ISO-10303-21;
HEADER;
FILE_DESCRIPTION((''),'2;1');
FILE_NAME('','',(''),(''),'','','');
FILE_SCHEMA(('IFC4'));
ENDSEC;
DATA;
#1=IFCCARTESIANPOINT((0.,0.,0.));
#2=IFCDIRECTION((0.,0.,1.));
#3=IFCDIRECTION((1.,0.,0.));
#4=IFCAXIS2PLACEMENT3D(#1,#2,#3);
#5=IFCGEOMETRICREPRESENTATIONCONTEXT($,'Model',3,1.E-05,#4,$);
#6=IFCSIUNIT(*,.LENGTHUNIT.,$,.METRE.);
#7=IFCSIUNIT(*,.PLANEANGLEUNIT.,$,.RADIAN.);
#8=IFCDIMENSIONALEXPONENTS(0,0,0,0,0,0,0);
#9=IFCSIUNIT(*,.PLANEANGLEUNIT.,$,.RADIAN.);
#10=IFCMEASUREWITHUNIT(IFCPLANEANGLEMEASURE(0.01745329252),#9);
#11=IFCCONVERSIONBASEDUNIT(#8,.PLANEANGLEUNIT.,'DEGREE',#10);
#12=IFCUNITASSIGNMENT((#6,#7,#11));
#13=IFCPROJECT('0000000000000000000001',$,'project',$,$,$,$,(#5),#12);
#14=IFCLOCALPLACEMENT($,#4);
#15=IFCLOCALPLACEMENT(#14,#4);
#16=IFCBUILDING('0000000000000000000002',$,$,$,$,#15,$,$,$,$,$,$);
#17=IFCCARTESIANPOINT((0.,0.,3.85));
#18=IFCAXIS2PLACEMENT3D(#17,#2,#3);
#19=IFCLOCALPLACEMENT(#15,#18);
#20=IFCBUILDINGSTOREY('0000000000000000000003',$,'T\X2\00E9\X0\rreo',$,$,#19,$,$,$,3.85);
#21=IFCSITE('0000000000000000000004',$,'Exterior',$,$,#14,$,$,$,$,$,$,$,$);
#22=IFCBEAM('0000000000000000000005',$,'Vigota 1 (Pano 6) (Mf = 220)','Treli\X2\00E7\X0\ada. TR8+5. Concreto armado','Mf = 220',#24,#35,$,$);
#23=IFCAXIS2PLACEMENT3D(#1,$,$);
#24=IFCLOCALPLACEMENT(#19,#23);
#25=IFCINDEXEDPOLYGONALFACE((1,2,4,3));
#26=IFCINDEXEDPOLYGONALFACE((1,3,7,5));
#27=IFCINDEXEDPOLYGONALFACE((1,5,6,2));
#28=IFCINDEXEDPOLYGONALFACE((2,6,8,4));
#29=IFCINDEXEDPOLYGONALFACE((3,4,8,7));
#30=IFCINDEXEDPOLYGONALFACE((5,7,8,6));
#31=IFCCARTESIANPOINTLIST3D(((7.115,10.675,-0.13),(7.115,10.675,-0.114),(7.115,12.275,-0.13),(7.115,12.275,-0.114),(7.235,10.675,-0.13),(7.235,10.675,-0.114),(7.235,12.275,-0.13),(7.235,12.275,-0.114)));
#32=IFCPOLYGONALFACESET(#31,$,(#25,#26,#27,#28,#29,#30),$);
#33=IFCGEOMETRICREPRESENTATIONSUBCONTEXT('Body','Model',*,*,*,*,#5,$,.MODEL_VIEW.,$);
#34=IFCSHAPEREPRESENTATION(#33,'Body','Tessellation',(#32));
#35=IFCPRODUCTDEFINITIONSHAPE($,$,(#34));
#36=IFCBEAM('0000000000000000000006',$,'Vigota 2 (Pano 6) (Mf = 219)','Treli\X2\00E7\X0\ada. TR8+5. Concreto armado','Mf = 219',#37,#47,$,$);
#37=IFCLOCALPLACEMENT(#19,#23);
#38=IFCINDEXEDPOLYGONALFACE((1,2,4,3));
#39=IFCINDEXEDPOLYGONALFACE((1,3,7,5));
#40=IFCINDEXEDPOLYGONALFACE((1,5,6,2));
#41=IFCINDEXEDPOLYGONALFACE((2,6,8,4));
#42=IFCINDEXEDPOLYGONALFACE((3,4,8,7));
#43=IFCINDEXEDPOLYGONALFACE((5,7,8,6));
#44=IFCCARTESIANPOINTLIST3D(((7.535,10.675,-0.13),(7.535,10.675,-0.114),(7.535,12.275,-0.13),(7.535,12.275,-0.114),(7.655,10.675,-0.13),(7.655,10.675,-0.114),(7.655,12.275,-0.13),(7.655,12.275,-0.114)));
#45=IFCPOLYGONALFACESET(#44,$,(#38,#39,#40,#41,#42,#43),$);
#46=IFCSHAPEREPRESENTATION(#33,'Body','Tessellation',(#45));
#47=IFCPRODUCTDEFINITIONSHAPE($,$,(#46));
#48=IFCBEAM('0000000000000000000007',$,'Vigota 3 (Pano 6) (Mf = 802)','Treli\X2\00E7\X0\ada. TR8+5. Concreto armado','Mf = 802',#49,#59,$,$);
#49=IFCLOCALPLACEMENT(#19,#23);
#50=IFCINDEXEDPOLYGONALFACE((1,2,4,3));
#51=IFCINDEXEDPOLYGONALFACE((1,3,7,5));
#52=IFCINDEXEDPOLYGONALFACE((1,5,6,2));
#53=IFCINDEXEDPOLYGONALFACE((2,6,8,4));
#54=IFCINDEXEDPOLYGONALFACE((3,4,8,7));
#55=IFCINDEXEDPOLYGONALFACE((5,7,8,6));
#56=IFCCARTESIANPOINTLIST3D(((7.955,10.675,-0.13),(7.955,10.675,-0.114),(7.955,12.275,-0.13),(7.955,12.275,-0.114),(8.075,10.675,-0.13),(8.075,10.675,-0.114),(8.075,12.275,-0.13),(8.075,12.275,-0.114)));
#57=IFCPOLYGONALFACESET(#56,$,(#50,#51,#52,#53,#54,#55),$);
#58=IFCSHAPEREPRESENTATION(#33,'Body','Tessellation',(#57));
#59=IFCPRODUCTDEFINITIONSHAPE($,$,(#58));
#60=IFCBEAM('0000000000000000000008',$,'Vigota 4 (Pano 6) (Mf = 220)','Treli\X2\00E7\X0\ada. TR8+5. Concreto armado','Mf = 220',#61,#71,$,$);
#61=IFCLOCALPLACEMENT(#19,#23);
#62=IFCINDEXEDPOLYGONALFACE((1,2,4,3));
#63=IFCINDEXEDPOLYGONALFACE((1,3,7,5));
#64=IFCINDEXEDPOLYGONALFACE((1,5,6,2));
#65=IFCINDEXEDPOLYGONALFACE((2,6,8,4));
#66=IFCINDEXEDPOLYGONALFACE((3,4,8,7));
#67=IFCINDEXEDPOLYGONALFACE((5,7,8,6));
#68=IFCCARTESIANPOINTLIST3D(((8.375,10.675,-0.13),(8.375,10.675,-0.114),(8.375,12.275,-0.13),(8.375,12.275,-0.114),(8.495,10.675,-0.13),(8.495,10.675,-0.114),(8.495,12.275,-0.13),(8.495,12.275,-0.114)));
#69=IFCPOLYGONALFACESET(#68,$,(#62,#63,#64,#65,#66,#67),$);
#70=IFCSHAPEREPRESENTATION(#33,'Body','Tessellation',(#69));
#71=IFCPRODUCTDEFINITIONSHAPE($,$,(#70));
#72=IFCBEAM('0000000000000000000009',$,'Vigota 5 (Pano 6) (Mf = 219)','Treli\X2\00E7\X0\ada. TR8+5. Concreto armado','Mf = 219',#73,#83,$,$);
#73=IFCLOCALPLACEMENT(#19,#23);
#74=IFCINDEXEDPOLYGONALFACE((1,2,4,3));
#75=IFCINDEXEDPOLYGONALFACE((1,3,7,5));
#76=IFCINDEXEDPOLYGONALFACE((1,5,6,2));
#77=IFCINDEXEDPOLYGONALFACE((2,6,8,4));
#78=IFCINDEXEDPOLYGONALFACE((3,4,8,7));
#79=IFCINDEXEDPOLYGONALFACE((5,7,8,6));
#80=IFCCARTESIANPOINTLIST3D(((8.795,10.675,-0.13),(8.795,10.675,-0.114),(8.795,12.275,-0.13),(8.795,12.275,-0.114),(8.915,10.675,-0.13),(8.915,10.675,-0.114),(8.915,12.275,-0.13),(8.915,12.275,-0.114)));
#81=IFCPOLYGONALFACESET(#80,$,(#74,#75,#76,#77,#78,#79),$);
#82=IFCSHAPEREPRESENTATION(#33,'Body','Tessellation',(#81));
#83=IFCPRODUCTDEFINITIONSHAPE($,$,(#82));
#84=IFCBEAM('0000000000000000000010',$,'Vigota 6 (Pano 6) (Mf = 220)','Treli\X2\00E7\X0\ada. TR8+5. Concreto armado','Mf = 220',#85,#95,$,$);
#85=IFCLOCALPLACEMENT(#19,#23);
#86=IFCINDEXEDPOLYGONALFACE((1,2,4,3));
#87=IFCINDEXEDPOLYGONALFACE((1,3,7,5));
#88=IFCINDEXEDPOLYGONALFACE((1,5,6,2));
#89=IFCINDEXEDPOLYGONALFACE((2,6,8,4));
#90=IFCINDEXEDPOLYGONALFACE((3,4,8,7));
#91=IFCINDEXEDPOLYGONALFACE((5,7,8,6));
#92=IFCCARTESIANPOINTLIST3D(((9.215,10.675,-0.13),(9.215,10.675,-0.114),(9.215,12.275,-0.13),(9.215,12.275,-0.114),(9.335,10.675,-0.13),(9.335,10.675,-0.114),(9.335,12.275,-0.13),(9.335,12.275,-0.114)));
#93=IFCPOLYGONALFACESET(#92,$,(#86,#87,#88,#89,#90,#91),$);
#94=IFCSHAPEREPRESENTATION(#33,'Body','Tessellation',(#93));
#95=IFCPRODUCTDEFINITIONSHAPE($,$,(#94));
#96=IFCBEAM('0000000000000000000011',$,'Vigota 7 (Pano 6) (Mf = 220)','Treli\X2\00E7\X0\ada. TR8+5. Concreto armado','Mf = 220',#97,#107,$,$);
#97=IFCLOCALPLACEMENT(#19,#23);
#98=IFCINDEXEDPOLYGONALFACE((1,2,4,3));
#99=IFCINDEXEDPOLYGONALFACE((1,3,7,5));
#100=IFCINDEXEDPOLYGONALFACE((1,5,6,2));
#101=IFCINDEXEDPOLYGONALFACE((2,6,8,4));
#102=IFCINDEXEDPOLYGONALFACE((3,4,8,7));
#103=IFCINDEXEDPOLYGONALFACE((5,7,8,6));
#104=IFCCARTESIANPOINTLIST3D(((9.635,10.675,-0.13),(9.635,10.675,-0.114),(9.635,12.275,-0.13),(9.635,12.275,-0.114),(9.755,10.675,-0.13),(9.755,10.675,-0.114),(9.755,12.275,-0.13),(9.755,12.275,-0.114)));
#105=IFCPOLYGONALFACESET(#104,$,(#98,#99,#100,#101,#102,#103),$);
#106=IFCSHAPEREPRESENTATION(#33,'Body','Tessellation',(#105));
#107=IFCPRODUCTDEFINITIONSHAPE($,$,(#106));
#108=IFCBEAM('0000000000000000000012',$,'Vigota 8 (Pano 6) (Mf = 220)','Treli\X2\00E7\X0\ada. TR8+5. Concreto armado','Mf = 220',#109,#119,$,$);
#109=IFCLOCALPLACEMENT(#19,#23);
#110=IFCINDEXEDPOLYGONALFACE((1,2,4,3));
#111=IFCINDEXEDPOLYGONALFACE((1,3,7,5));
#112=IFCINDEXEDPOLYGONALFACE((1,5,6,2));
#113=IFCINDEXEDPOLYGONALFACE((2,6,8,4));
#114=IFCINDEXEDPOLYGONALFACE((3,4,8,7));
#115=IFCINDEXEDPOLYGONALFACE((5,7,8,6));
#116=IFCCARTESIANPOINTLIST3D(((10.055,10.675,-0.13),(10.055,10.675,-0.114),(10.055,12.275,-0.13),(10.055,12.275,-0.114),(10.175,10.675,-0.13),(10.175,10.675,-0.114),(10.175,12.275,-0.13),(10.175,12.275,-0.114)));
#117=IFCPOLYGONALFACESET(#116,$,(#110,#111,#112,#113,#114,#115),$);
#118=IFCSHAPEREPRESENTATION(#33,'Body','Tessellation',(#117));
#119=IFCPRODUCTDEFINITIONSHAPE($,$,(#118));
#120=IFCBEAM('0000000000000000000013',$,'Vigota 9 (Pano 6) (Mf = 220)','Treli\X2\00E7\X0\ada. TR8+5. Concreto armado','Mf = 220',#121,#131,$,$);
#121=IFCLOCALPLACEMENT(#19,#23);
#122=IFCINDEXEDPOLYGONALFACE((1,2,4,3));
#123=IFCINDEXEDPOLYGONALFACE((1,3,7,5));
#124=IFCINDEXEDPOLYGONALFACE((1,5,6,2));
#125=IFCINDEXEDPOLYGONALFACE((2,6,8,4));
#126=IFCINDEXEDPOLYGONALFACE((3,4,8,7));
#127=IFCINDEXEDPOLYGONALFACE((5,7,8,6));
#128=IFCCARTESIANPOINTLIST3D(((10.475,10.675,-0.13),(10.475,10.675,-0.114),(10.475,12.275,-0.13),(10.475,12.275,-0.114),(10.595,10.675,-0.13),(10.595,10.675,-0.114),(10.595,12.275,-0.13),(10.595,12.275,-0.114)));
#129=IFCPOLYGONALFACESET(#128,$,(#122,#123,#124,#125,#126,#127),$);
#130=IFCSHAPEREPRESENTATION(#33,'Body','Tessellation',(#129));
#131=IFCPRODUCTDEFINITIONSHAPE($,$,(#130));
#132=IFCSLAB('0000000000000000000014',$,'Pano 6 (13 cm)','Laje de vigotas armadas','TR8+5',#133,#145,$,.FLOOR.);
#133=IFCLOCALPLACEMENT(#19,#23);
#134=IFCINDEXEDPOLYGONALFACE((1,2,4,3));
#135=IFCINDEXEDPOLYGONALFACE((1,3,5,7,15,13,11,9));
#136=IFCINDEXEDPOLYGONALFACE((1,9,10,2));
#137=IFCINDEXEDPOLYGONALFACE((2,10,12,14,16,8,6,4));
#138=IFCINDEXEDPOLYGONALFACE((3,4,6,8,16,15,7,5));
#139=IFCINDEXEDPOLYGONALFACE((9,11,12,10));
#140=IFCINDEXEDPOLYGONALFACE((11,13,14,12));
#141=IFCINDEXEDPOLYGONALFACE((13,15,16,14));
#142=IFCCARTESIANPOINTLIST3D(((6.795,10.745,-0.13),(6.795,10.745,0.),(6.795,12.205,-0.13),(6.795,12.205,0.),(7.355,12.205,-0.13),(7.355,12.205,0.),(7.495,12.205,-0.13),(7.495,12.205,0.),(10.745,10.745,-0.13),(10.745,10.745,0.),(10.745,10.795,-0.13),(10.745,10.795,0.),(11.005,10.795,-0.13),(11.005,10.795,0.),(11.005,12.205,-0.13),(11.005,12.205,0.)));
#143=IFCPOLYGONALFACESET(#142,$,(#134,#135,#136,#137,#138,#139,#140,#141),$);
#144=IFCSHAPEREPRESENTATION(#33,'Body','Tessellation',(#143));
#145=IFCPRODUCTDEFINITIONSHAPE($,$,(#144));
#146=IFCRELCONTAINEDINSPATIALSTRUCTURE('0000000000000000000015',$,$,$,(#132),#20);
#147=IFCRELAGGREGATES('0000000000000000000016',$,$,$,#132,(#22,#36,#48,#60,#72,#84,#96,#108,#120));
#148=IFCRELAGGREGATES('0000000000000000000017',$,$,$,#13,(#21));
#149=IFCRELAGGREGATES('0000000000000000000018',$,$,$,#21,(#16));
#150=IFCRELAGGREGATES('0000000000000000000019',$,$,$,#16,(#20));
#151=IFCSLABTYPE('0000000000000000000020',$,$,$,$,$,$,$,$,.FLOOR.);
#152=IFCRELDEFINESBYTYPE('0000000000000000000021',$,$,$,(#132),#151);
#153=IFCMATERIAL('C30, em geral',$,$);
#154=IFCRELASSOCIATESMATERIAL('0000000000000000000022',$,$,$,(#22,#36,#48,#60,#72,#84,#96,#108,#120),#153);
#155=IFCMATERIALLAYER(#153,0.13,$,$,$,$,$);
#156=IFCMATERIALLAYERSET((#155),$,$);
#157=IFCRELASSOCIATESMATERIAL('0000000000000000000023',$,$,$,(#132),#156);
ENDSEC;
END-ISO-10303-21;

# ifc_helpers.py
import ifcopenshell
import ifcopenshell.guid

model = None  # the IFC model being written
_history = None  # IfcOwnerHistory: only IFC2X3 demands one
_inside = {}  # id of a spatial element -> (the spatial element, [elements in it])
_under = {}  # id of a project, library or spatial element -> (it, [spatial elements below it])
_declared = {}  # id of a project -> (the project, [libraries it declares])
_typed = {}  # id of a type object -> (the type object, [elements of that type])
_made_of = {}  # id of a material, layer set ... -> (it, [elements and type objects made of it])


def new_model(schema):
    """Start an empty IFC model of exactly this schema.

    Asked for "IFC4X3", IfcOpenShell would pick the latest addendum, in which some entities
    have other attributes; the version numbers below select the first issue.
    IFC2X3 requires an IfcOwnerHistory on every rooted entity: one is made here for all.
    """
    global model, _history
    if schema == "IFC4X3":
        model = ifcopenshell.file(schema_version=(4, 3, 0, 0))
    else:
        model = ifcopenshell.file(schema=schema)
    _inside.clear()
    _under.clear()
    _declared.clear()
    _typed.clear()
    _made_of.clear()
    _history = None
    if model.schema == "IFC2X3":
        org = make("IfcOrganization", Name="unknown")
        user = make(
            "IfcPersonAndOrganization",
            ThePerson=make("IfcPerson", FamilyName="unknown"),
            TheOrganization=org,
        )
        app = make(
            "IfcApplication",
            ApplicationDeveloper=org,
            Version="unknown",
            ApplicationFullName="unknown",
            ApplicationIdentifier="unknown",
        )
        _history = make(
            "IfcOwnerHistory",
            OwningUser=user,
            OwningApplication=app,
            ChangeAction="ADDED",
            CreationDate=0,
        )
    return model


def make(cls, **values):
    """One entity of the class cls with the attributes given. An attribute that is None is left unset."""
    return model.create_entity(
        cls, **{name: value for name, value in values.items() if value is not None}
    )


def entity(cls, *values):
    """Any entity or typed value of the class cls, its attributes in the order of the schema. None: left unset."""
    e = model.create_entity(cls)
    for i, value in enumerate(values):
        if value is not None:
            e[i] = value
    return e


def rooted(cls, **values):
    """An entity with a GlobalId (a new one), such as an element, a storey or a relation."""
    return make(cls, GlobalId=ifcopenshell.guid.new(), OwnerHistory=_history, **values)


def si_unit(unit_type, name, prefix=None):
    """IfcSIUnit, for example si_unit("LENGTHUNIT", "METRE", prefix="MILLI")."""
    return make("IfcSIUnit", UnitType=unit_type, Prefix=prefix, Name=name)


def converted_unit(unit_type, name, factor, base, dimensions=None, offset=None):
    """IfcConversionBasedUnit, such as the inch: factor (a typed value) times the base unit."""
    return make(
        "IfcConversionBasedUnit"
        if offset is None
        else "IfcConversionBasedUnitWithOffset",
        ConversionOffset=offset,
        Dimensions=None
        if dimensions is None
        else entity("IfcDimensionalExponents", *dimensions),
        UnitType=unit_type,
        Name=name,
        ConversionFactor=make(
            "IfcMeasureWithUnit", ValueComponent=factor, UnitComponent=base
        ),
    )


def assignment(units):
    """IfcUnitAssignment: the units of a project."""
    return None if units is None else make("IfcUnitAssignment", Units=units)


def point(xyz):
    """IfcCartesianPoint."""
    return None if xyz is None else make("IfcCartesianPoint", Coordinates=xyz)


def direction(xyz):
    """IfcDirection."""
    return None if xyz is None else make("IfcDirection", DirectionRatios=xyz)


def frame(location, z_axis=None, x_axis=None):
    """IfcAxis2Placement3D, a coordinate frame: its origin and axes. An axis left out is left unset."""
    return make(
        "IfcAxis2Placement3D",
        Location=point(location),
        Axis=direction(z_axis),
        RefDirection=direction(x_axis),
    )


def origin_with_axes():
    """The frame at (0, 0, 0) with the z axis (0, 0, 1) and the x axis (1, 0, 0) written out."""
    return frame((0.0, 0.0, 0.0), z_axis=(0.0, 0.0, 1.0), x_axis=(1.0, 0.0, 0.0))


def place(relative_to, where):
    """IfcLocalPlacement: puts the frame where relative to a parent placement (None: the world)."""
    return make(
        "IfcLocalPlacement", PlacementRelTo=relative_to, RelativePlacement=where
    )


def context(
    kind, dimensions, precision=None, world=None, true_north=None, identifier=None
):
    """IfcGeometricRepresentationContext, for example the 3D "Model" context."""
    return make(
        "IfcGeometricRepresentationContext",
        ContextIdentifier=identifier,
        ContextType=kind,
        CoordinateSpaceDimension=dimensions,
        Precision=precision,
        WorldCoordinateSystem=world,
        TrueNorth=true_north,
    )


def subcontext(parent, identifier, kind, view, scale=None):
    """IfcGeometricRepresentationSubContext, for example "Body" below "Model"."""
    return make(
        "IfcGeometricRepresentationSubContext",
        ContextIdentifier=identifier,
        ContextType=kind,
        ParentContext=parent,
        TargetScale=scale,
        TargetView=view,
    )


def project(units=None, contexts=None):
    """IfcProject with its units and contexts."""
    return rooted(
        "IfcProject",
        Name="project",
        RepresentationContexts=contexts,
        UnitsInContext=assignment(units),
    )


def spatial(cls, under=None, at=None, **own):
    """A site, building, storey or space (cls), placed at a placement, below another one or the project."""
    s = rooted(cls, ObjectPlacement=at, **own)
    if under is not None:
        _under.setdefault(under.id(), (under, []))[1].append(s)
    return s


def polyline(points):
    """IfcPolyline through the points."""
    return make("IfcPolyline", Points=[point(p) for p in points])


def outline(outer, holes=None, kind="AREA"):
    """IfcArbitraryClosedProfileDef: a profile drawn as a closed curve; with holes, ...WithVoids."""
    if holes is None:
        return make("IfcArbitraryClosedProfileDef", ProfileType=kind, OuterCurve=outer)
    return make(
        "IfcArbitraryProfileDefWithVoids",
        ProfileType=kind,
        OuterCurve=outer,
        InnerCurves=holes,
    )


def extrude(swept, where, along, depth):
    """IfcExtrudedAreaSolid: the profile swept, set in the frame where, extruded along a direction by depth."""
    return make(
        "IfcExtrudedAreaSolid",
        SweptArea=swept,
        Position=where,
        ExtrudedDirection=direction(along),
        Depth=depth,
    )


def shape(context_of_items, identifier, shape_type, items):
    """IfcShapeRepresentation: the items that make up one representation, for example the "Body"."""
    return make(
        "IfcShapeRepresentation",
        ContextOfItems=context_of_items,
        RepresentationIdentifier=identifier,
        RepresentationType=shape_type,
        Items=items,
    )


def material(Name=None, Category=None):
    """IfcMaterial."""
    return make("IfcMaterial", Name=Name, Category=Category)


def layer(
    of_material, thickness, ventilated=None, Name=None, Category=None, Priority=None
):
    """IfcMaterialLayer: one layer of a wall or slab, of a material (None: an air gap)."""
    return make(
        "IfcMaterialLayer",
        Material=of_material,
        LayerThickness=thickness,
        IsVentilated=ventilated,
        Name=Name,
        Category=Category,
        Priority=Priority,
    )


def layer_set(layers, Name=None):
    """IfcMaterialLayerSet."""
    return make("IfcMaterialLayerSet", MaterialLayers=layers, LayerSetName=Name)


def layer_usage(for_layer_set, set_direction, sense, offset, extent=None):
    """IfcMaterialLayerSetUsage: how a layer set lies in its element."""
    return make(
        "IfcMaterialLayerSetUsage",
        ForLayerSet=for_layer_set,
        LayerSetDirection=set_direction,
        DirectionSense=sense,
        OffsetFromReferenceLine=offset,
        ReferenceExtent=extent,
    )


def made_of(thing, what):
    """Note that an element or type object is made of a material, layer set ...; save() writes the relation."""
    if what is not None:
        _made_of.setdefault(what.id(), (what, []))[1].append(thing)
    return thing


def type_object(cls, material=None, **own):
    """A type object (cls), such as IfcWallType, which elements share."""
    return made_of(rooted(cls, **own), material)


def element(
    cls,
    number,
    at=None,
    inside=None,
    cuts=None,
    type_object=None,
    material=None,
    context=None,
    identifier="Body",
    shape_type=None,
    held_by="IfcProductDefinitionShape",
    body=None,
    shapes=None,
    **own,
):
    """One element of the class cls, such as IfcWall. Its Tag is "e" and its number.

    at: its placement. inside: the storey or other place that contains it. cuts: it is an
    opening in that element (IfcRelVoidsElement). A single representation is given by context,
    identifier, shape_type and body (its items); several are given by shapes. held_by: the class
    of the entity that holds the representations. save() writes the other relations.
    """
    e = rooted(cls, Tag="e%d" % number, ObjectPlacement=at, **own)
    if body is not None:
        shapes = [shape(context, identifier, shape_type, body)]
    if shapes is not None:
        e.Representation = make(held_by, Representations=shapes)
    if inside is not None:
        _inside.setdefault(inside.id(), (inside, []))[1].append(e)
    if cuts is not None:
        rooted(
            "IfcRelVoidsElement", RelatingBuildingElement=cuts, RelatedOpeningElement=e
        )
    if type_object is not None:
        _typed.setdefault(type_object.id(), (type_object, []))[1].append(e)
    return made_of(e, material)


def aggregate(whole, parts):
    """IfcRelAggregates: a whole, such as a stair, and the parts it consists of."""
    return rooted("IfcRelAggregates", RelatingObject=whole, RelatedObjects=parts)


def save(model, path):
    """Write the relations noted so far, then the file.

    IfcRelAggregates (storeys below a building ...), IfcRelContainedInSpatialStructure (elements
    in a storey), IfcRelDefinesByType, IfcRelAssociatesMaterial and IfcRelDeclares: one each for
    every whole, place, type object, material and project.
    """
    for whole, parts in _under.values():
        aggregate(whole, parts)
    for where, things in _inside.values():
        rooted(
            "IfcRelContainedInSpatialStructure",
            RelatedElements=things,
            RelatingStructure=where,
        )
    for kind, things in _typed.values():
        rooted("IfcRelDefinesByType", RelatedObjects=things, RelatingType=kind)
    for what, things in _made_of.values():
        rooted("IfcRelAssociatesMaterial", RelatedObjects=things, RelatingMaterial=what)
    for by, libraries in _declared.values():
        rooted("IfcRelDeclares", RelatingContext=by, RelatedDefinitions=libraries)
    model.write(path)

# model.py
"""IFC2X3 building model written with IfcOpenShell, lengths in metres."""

from ifc_helpers import new_model, entity, si_unit, converted_unit, frame, origin_with_axes, place, context, subcontext, project, spatial, polyline, outline, extrude, material, layer, layer_set, layer_usage, type_object, element, aggregate, save


model = new_model("IFC2X3")

# Units and contexts
model_context = context("Model", 3, precision=1e-05, world=origin_with_axes())
body_context = subcontext(model_context, "Body", "Model", "MODEL_VIEW")
ifc_project = project(units=[si_unit("LENGTHUNIT", "METRE"), si_unit("PLANEANGLEUNIT", "RADIAN"), converted_unit("PLANEANGLEUNIT", "DEGREE", entity("IfcPlaneAngleMeasure", 0.01745329252), si_unit("PLANEANGLEUNIT", "RADIAN"), dimensions=[0, 0, 0, 0, 0, 0, 0])], contexts=[model_context])

# Beams
ifc_material = material(Name="C30, em geral")
site_placement = place(None, origin_with_axes())
building_placement = place(site_placement, origin_with_axes())
storey_placement = place(building_placement, frame((0.0, 0.0, 3.85), z_axis=(0.0, 0.0, 1.0), x_axis=(1.0, 0.0, 0.0)))
beam_1_placement = place(storey_placement, frame((7.175, 10.675, -0.122), z_axis=(0.0, 1.0, 0.0), x_axis=(-1.0, 0.0, 0.0)))
beam_1 = element("IfcBeam", 1, at=beam_1_placement, material=ifc_material, Name="Vigota 1 (Pano 6) (Mf = 220)", Description="Treliçada. TR8+5. Concreto armado", ObjectType="Mf = 220", context=body_context, shape_type="SweptSolid", body=[
    extrude(outline(polyline([(0.06, 0.008), (-0.06, 0.008), (-0.06, -0.008), (0.06, -0.008), (0.06, 0.008)])), origin_with_axes(), (0.0, 0.0, 1.0), 1.6),
])
beam_2_placement = place(storey_placement, frame((7.595, 10.675, -0.122), z_axis=(0.0, 1.0, 0.0), x_axis=(-1.0, 0.0, 0.0)))
beam_2 = element("IfcBeam", 2, at=beam_2_placement, material=ifc_material, Name="Vigota 2 (Pano 6) (Mf = 219)", Description="Treliçada. TR8+5. Concreto armado", ObjectType="Mf = 219", context=body_context, shape_type="SweptSolid", body=[
    extrude(outline(polyline([(0.06, 0.008), (-0.06, 0.008), (-0.06, -0.008), (0.06, -0.008), (0.06, 0.008)])), origin_with_axes(), (0.0, 0.0, 1.0), 1.6),
])
beam_3_placement = place(storey_placement, frame((8.015, 10.675, -0.122), z_axis=(0.0, 1.0, 0.0), x_axis=(-1.0, 0.0, 0.0)))
beam_3 = element("IfcBeam", 3, at=beam_3_placement, material=ifc_material, Name="Vigota 3 (Pano 6) (Mf = 802)", Description="Treliçada. TR8+5. Concreto armado", ObjectType="Mf = 802", context=body_context, shape_type="SweptSolid", body=[
    extrude(outline(polyline([(0.06, 0.008), (-0.06, 0.008), (-0.06, -0.008), (0.06, -0.008), (0.06, 0.008)])), origin_with_axes(), (0.0, 0.0, 1.0), 1.6),
])
beam_4_placement = place(storey_placement, frame((8.435, 10.675, -0.122), z_axis=(0.0, 1.0, 0.0), x_axis=(-1.0, 0.0, 0.0)))
beam_4 = element("IfcBeam", 4, at=beam_4_placement, material=ifc_material, Name="Vigota 4 (Pano 6) (Mf = 220)", Description="Treliçada. TR8+5. Concreto armado", ObjectType="Mf = 220", context=body_context, shape_type="SweptSolid", body=[
    extrude(outline(polyline([(0.06, 0.008), (-0.06, 0.008), (-0.06, -0.008), (0.06, -0.008), (0.06, 0.008)])), origin_with_axes(), (0.0, 0.0, 1.0), 1.6),
])
beam_5_placement = place(storey_placement, frame((8.855, 10.675, -0.122), z_axis=(0.0, 1.0, 0.0), x_axis=(-1.0, 0.0, 0.0)))
beam_5 = element("IfcBeam", 5, at=beam_5_placement, material=ifc_material, Name="Vigota 5 (Pano 6) (Mf = 219)", Description="Treliçada. TR8+5. Concreto armado", ObjectType="Mf = 219", context=body_context, shape_type="SweptSolid", body=[
    extrude(outline(polyline([(0.06, 0.008), (-0.06, 0.008), (-0.06, -0.008), (0.06, -0.008), (0.06, 0.008)])), origin_with_axes(), (0.0, 0.0, 1.0), 1.6),
])
beam_6_placement = place(storey_placement, frame((9.275, 10.675, -0.122), z_axis=(0.0, 1.0, 0.0), x_axis=(-1.0, 0.0, 0.0)))
beam_6 = element("IfcBeam", 6, at=beam_6_placement, material=ifc_material, Name="Vigota 6 (Pano 6) (Mf = 220)", Description="Treliçada. TR8+5. Concreto armado", ObjectType="Mf = 220", context=body_context, shape_type="SweptSolid", body=[
    extrude(outline(polyline([(0.06, 0.008), (-0.06, 0.008), (-0.06, -0.008), (0.06, -0.008), (0.06, 0.008)])), origin_with_axes(), (0.0, 0.0, 1.0), 1.6),
])
beam_7_placement = place(storey_placement, frame((9.695, 10.675, -0.122), z_axis=(0.0, 1.0, 0.0), x_axis=(-1.0, 0.0, 0.0)))
beam_7 = element("IfcBeam", 7, at=beam_7_placement, material=ifc_material, Name="Vigota 7 (Pano 6) (Mf = 220)", Description="Treliçada. TR8+5. Concreto armado", ObjectType="Mf = 220", context=body_context, shape_type="SweptSolid", body=[
    extrude(outline(polyline([(0.06, 0.008), (-0.06, 0.008), (-0.06, -0.008), (0.06, -0.008), (0.06, 0.008)])), origin_with_axes(), (0.0, 0.0, 1.0), 1.6),
])
beam_8_placement = place(storey_placement, frame((10.115, 10.675, -0.122), z_axis=(0.0, 1.0, 0.0), x_axis=(-1.0, 0.0, 0.0)))
beam_8 = element("IfcBeam", 8, at=beam_8_placement, material=ifc_material, Name="Vigota 8 (Pano 6) (Mf = 220)", Description="Treliçada. TR8+5. Concreto armado", ObjectType="Mf = 220", context=body_context, shape_type="SweptSolid", body=[
    extrude(outline(polyline([(0.06, 0.008), (-0.06, 0.008), (-0.06, -0.008), (0.06, -0.008), (0.06, 0.008)])), origin_with_axes(), (0.0, 0.0, 1.0), 1.6),
])
beam_9_placement = place(storey_placement, frame((10.535, 10.675, -0.122), z_axis=(0.0, 1.0, 0.0), x_axis=(-1.0, 0.0, 0.0)))
beam_9 = element("IfcBeam", 9, at=beam_9_placement, material=ifc_material, Name="Vigota 9 (Pano 6) (Mf = 220)", Description="Treliçada. TR8+5. Concreto armado", ObjectType="Mf = 220", context=body_context, shape_type="SweptSolid", body=[
    extrude(outline(polyline([(0.06, 0.008), (-0.06, 0.008), (-0.06, -0.008), (0.06, -0.008), (0.06, 0.008)])), origin_with_axes(), (0.0, 0.0, 1.0), 1.6),
])

# Site, building, storey
site = spatial("IfcSite", under=ifc_project, at=site_placement, Name="Exterior")
building = spatial("IfcBuilding", under=site, at=building_placement)
storey = spatial("IfcBuildingStorey", under=building, at=storey_placement, Name="Térreo", Elevation=3.85)

# Slab
ifc_layer_1 = layer(ifc_material, 0.13)
ifc_layer_set_1 = layer_set([ifc_layer_1])
ifc_layer_usage_1 = layer_usage(ifc_layer_set_1, "AXIS3", "POSITIVE", 0.0)
slab_type = type_object("IfcSlabType", PredefinedType="FLOOR")
slab_1_placement = place(storey_placement, frame((0.0, 0.0, -0.13), z_axis=(0.0, 0.0, 1.0), x_axis=(1.0, 0.0, 0.0)))
slab_1 = element("IfcSlab", 10, at=slab_1_placement, inside=storey, type_object=slab_type, material=ifc_layer_usage_1, Name="Pano 6 (13 cm)", Description="Laje de vigotas armadas", ObjectType="TR8+5", PredefinedType="FLOOR", context=body_context, shape_type="SweptSolid", body=[
    extrude(outline(polyline([(11.005, 10.795), (11.005, 12.205), (7.495, 12.205), (7.355, 12.205), (6.795, 12.205), (6.795, 10.745), (10.745, 10.745), (10.745, 10.795), (11.005, 10.795)])), origin_with_axes(), (0.0, 0.0, 1.0), 0.13),
])
aggregate(slab_1, [beam_1, beam_2, beam_3, beam_4, beam_5, beam_6, beam_7, beam_8, beam_9])

save(model, "model.ifc")
